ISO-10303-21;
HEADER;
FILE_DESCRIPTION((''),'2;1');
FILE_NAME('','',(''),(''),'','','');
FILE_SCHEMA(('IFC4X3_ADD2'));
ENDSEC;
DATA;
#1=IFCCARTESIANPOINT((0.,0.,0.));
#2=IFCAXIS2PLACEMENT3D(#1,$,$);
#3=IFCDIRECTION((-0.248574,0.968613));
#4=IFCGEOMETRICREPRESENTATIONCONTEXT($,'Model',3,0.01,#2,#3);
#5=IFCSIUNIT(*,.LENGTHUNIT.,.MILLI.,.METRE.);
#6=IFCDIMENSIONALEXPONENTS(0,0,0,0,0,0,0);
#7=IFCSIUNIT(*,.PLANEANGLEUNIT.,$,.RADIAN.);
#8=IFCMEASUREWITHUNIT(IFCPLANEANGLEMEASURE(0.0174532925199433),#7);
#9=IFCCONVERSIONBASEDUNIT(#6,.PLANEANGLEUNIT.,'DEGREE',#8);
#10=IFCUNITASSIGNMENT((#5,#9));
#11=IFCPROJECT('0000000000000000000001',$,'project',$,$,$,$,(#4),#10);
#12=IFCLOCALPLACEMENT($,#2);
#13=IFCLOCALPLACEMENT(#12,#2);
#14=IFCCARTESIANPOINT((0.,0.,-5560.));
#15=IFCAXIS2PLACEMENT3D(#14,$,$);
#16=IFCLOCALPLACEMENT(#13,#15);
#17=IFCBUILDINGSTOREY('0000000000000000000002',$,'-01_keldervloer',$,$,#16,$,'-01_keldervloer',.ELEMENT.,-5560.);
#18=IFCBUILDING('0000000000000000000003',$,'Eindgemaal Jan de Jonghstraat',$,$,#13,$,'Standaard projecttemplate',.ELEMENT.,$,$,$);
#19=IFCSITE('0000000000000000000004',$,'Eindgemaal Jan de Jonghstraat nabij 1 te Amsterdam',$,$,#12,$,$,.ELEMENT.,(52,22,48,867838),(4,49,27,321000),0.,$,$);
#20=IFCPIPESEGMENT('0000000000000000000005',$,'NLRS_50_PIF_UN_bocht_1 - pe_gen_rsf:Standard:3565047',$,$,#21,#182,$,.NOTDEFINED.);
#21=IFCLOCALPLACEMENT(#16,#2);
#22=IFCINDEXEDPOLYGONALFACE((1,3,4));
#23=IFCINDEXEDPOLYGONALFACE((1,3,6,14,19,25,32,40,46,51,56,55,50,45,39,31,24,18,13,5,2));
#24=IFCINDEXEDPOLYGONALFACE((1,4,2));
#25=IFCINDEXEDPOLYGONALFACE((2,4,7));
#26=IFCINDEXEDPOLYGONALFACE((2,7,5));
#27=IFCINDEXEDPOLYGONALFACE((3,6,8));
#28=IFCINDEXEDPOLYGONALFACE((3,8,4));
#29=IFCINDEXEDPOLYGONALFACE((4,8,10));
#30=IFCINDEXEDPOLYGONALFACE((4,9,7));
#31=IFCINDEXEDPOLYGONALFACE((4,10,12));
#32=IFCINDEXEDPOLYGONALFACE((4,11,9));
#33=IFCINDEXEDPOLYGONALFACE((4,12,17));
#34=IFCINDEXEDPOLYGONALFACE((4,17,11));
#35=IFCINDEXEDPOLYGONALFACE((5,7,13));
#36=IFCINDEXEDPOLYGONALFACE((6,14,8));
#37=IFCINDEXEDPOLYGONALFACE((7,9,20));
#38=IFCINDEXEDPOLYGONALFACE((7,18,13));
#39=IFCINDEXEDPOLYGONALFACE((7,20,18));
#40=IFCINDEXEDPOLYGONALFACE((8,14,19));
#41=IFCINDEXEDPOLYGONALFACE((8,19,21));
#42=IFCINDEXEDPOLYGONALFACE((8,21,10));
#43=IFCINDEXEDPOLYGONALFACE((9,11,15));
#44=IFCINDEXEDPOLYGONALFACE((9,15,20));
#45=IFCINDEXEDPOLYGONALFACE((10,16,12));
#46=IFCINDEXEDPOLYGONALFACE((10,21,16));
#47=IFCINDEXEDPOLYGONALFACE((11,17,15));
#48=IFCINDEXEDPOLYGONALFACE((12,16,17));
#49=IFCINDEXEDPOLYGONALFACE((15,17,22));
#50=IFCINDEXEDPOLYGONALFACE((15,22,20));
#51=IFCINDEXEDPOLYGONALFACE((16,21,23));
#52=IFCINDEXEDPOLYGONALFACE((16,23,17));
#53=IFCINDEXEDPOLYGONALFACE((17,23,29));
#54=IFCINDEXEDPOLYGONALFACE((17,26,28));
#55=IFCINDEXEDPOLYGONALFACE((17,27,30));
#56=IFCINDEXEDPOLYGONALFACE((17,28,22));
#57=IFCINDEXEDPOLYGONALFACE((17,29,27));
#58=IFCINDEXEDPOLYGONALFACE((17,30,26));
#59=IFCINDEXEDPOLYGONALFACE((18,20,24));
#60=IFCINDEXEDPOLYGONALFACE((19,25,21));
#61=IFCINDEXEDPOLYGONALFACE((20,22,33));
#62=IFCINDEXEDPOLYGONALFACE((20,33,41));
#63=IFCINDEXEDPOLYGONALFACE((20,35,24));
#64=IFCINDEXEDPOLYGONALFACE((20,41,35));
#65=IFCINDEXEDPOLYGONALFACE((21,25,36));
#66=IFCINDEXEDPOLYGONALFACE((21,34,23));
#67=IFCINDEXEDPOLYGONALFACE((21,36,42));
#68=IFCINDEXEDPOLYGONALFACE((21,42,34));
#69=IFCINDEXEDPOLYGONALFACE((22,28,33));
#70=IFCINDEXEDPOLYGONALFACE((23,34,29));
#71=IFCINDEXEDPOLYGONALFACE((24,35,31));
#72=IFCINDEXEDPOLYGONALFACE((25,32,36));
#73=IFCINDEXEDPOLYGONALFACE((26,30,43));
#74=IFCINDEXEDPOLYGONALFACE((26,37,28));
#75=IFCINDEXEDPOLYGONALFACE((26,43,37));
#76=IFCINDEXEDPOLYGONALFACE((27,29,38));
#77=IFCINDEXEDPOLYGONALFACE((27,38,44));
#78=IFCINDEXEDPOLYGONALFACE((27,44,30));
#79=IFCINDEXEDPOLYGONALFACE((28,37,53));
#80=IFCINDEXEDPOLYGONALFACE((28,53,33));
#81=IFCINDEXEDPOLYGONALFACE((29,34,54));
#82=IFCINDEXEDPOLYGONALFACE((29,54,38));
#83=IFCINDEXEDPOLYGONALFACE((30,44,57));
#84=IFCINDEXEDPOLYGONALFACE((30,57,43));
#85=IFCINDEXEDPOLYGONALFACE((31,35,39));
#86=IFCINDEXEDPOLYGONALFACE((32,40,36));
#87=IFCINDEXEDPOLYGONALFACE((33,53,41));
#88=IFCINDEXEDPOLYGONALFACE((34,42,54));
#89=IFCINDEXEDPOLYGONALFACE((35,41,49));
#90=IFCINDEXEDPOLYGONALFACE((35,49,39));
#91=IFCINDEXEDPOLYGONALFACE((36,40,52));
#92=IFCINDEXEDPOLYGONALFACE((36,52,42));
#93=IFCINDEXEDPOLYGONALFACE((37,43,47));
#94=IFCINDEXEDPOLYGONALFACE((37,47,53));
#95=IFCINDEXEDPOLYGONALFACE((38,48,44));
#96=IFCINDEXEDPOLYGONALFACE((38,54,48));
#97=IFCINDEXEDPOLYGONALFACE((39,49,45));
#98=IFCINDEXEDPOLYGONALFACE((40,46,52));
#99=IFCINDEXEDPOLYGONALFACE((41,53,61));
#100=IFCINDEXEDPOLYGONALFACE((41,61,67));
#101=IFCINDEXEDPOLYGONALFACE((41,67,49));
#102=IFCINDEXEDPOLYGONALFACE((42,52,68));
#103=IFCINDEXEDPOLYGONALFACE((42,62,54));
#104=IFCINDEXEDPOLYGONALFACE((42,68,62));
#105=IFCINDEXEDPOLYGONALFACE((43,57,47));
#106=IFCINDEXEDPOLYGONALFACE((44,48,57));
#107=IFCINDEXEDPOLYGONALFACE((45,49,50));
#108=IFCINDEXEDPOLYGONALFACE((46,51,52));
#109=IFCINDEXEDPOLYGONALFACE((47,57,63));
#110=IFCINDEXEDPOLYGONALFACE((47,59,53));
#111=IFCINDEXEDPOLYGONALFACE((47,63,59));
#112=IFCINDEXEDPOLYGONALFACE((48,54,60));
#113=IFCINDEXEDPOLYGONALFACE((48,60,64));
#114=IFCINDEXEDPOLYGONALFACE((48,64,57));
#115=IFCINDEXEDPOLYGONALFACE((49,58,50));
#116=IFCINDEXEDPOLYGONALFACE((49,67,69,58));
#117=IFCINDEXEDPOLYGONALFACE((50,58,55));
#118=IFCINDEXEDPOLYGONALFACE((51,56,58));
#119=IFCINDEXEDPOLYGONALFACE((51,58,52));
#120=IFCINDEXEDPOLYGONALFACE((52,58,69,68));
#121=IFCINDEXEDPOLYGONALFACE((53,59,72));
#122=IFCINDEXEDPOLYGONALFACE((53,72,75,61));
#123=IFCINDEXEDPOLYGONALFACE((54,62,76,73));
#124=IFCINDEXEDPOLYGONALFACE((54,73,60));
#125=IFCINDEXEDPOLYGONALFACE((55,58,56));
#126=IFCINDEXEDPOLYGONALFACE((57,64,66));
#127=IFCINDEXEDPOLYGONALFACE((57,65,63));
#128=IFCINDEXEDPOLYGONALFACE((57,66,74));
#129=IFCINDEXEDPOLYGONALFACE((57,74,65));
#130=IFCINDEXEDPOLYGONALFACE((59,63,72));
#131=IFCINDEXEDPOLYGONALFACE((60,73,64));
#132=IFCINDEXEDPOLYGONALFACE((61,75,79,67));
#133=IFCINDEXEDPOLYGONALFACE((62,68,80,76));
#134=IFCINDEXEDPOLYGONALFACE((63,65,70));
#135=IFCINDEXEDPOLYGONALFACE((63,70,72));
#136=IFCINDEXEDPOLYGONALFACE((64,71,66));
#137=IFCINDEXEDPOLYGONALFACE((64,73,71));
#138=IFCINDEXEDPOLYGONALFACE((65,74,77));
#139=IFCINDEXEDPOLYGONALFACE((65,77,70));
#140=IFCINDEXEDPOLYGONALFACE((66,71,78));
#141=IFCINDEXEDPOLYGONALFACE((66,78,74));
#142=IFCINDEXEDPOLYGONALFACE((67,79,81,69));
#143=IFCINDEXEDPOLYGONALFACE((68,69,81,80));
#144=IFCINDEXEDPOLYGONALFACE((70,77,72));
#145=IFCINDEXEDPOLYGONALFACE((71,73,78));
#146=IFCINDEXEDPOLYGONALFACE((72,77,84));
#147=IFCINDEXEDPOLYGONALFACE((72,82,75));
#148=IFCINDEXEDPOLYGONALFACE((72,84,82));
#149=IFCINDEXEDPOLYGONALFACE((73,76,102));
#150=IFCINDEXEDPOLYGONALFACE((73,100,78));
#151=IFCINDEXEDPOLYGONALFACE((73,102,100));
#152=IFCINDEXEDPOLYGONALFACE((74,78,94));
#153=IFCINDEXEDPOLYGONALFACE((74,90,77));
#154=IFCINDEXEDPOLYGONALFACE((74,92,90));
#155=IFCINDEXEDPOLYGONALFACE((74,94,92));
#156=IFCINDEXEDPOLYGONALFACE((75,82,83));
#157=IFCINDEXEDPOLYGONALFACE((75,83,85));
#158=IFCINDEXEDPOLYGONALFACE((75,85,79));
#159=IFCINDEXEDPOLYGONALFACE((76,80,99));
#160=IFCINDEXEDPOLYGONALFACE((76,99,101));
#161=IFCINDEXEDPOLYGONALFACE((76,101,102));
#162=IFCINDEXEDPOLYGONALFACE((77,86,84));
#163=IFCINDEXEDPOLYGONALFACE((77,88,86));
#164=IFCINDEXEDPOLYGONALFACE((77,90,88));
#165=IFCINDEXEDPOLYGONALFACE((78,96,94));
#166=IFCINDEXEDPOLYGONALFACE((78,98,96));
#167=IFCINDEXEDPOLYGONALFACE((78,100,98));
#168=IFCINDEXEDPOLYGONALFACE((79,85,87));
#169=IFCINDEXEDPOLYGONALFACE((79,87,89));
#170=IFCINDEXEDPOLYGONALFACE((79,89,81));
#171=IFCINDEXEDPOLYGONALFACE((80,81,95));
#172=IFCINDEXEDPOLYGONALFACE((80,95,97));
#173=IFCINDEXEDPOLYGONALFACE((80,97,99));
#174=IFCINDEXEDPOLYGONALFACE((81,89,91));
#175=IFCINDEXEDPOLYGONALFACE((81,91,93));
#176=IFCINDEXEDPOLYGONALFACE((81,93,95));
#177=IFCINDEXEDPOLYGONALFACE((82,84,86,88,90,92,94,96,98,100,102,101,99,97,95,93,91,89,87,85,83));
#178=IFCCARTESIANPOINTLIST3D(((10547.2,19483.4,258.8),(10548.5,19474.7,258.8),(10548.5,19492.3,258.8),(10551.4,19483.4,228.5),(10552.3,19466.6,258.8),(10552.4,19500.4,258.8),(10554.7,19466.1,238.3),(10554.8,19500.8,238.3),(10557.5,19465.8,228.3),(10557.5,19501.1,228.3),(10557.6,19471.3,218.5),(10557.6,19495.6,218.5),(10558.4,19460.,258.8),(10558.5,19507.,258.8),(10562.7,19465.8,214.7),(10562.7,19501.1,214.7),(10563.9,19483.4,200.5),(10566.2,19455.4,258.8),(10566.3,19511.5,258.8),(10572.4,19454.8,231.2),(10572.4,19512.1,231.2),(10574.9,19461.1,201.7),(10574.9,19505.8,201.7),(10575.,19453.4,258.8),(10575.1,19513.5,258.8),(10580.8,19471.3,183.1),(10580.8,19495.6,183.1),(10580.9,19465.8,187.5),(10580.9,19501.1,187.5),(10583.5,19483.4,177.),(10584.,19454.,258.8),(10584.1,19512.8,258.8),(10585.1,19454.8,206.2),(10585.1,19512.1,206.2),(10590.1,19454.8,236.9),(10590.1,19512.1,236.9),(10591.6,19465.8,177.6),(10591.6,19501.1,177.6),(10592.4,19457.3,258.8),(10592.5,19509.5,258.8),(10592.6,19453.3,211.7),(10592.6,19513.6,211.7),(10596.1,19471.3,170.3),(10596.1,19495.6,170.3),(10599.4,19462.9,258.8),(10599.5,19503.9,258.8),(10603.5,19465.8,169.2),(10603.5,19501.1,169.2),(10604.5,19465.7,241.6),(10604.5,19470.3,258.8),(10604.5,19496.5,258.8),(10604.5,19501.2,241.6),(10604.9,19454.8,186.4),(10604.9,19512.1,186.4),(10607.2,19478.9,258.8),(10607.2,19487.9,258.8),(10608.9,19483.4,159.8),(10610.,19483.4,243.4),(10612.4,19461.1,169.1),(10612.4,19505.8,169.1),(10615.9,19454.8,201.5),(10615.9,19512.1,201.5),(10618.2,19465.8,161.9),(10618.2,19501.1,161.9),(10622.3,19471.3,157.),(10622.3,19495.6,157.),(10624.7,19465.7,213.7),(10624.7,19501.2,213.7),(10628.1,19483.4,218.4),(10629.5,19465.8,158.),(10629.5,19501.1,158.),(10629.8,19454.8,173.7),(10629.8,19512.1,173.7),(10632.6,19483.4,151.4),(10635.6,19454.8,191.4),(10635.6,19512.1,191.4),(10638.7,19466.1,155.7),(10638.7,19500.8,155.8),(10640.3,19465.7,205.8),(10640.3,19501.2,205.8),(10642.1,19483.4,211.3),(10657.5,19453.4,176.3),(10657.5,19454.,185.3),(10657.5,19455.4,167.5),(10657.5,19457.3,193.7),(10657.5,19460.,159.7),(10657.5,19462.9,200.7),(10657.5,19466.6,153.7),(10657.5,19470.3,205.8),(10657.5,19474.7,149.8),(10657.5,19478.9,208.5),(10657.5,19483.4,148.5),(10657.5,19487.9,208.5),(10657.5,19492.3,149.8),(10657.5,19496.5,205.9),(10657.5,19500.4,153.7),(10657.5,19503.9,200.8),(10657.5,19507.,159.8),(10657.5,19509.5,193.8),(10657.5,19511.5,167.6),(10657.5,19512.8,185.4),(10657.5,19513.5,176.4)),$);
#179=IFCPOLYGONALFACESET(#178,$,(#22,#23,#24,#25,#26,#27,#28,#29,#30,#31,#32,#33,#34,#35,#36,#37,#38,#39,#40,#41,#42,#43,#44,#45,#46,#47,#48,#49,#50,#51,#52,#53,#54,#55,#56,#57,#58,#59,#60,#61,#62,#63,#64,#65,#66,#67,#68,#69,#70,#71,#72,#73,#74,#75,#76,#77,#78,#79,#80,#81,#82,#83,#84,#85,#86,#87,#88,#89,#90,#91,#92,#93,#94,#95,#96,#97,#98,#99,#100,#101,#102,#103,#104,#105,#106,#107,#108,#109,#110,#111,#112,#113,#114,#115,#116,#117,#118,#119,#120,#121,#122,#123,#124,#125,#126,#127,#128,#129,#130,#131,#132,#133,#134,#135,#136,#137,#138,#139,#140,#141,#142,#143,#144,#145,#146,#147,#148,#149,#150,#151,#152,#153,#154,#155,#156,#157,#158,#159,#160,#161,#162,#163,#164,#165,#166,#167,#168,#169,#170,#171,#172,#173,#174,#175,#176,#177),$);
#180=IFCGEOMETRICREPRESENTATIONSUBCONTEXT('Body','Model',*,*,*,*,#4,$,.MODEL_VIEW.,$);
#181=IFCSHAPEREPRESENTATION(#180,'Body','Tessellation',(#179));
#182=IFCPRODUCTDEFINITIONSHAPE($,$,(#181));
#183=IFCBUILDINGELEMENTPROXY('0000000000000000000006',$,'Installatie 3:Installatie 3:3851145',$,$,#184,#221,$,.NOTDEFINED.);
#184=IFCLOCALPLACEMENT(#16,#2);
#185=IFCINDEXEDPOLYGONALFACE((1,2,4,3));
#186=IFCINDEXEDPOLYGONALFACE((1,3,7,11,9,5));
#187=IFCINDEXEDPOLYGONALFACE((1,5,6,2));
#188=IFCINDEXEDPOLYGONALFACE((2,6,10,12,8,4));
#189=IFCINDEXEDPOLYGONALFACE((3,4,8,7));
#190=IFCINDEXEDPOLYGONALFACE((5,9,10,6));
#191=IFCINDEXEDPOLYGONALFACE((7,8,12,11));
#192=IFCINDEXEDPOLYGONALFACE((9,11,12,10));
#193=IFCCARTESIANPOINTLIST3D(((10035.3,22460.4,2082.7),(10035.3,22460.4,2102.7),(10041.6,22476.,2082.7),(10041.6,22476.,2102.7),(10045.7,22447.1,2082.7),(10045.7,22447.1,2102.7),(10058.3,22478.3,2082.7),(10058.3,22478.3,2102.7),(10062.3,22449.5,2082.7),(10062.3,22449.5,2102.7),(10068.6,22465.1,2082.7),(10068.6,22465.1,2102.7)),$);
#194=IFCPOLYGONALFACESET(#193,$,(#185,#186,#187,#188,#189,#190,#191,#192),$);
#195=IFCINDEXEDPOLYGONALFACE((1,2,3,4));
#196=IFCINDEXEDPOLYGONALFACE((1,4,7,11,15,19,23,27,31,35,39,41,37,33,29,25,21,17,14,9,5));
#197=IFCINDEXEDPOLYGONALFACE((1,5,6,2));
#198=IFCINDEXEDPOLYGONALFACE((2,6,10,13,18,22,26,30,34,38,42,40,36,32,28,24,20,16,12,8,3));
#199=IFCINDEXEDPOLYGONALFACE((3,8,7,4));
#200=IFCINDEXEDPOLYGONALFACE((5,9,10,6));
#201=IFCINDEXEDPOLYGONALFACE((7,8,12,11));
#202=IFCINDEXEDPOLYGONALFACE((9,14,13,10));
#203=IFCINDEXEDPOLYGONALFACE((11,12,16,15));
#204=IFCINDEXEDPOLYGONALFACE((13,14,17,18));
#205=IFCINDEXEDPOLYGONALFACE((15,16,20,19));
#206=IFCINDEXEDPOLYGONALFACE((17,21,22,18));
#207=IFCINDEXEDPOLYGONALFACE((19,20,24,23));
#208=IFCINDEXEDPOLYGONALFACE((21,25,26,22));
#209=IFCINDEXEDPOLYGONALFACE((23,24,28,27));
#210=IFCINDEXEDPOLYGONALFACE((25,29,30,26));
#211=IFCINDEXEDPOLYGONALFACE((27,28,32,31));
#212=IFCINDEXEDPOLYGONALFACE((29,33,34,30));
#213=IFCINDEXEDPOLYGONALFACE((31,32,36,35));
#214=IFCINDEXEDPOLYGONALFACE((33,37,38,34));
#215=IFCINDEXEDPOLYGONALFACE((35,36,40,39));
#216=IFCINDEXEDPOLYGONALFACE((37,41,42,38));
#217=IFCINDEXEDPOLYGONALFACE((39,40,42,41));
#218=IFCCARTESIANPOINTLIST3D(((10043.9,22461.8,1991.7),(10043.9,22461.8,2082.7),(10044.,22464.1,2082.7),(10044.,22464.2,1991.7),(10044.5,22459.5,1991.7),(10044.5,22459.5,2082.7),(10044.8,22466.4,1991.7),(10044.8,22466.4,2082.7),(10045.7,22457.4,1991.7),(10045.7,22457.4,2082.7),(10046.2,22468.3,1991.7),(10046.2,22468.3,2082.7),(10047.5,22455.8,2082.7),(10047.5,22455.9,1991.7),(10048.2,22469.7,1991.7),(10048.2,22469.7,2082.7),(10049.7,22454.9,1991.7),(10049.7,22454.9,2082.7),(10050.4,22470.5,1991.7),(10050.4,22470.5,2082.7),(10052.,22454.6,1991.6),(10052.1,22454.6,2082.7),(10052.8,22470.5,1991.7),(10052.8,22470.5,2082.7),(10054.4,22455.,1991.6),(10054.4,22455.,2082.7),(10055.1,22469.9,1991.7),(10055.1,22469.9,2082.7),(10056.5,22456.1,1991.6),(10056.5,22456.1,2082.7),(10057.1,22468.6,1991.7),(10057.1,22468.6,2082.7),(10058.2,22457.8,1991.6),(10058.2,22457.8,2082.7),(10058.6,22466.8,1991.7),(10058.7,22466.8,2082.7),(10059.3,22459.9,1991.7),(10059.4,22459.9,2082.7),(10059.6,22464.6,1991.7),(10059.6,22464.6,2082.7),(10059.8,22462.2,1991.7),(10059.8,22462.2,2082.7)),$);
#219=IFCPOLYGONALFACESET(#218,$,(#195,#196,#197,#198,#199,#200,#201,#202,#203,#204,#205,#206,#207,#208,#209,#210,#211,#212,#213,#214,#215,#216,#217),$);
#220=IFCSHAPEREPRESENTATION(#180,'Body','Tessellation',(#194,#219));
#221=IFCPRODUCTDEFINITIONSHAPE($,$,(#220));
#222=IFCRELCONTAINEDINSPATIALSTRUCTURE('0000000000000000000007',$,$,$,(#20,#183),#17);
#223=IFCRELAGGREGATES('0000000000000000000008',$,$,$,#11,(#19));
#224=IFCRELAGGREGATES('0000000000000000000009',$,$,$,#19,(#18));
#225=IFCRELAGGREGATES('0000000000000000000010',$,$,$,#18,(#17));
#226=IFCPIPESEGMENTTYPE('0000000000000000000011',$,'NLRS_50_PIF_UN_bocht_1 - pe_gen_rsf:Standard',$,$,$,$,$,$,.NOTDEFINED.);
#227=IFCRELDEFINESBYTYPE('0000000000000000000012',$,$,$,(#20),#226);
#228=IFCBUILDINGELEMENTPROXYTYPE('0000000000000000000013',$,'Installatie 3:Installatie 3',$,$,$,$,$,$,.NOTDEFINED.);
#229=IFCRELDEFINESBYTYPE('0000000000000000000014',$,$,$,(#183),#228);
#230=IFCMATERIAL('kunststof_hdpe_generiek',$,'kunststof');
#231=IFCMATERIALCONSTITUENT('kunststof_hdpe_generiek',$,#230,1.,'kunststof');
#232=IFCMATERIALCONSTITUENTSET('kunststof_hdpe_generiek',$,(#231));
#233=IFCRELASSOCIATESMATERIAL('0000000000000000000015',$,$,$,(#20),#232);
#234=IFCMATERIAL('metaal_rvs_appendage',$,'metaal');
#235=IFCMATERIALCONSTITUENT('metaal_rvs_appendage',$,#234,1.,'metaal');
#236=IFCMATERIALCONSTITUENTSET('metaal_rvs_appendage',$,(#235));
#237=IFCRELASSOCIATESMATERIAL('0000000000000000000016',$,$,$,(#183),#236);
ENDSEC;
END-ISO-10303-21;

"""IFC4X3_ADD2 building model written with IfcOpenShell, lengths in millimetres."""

from ifc_helpers import new_model, entity, si_unit, converted_unit, direction, frame, frame_2d, origin, place, context, subcontext, project, spatial, polyline, circle, outline, extrude, source, transform, mapped, material, constituent, constituent_set, type_object, type_shapes, element, save


model = new_model("IFC4X3_ADD2")

# Units and contexts
model_context = context("Model", 3, precision=0.01, world=origin(), true_north=direction((-0.248574, 0.968613)))
body_context = subcontext(model_context, "Body", "Model", "MODEL_VIEW")
ifc_project = project(units=[si_unit("LENGTHUNIT", "METRE", prefix="MILLI"), converted_unit("PLANEANGLEUNIT", "DEGREE", entity("IfcPlaneAngleMeasure", 0.0174532925199433), si_unit("PLANEANGLEUNIT", "RADIAN"), dimensions=[0, 0, 0, 0, 0, 0, 0])], contexts=[model_context])

# Site, building, storey
site_placement = place(None, origin())
site = spatial("IfcSite", under=ifc_project, at=site_placement, Name="Eindgemaal Jan de Jonghstraat nabij 1 te Amsterdam", CompositionType="ELEMENT", RefLatitude=(52, 22, 48, 867838), RefLongitude=(4, 49, 27, 321000), RefElevation=0.0)
building_placement = place(site_placement, origin())
building = spatial("IfcBuilding", under=site, at=building_placement, Name="Eindgemaal Jan de Jonghstraat", LongName="Standaard projecttemplate", CompositionType="ELEMENT")
storey_placement = place(building_placement, frame((0.0, 0.0, -5560.0)))
storey = spatial("IfcBuildingStorey", under=building, at=storey_placement, Name="-01_keldervloer", LongName="-01_keldervloer", CompositionType="ELEMENT", Elevation=-5560.0)

# Pipe segment
ifc_material_1 = material(Name="kunststof_hdpe_generiek", Category="kunststof")
ifc_constituent_1 = constituent(ifc_material_1, Name="kunststof_hdpe_generiek", Category="kunststof", fraction=1.0)
ifc_constituent_set_1 = constituent_set(constituents=[ifc_constituent_1], Name="kunststof_hdpe_generiek")
pipe_segment_type_1 = type_object("IfcPipeSegmentType", Name="NLRS_50_PIF_UN_bocht_1 - pe_gen_rsf:Standard", PredefinedType="NOTDEFINED")
trimmed_curve_1 = entity("IfcTrimmedCurve", entity("IfcCircle", entity("IfcAxis2Placement2D", entity("IfcCartesianPoint", [-50.0, 0.0]), entity("IfcDirection", [0.0, 1.0])), 50.0), [entity("IfcParameterValue", 270.0)], [entity("IfcParameterValue", 0.0)], True, "PARAMETER")
shared_shape_1 = source(origin(), body_context, "Body", "AdvancedSweptSolid", [
    entity("IfcSurfaceCurveSweptAreaSolid", entity("IfcCircleProfileDef", "AREA", None, entity("IfcAxis2Placement2D", entity("IfcCartesianPoint", [30.1, 0.0]), entity("IfcDirection", [1.0, 0.0])), 30.1), entity("IfcAxis2Placement3D", entity("IfcCartesianPoint", [-30.1, 80.1, 0.0]), entity("IfcDirection", [0.0, 0.0, -1.0]), entity("IfcDirection", [1.0, 0.0, 0.0])), trimmed_curve_1, entity("IfcParameterValue", 0.0), entity("IfcParameterValue", 90.0), entity("IfcSurfaceOfLinearExtrusion", entity("IfcArbitraryOpenProfileDef", "CURVE", None, trimmed_curve_1), entity("IfcAxis2Placement3D", entity("IfcCartesianPoint", [0.0, 0.0, -304.8])), entity("IfcDirection", [0.0, 0.0, 1.0]), 1.0)),
])
type_shapes(pipe_segment_type_1, [shared_shape_1])
pipe_segment_1_placement = place(storey_placement, frame((10577.4, 19483.4, 178.7), z_axis=(0.0, 1.0, 0.0), x_axis=(-1.0, 0.0, 0.0)))
element("IfcPipeSegment", 1, at=pipe_segment_1_placement, inside=storey, type_object=pipe_segment_type_1, material=ifc_constituent_set_1, Name="NLRS_50_PIF_UN_bocht_1 - pe_gen_rsf:Standard:3565047", PredefinedType="NOTDEFINED", context=body_context, shape_type="MappedRepresentation", body=[
    mapped(shared_shape_1, transform((0.0, 0.0, 0.0), scale=1.0)),
])

# Building element proxy
ifc_material_2 = material(Name="metaal_rvs_appendage", Category="metaal")
ifc_constituent_2 = constituent(ifc_material_2, Name="metaal_rvs_appendage", Category="metaal", fraction=1.0)
ifc_constituent_set_2 = constituent_set(constituents=[ifc_constituent_2], Name="metaal_rvs_appendage")
building_element_proxy_type_1 = type_object("IfcBuildingElementProxyType", Name="Installatie 3:Installatie 3", PredefinedType="NOTDEFINED")
shared_shape_2 = source(origin(), body_context, "Body", "SweptSolid", [
    extrude(outline(polyline([(-8.4, -14.6), (8.4, -14.6), (16.8, 0.0), (8.4, 14.6), (-8.4, 14.6), (-16.8, 0.0), (-8.4, -14.6)])), frame((0.0, 0.0, 41.5), z_axis=(0.0, 0.0, 1.0), x_axis=(-0.400458, 0.916315, 0.0)), (0.0, 0.0, 1.0), 20.0),
    extrude(circle(Radius=8.0, at=frame_2d((0.0, 0.0), x_axis=(1.0, 0.0))), frame((-0.2, -0.1, -49.5), z_axis=(0.000101, -0.000286, 1.0), x_axis=(1.0, 0.0, -0.000101)), (0.0, 0.0, 1.0), 91.1),
])
type_shapes(building_element_proxy_type_1, [shared_shape_2])
for number, where, z_axis, x_axis, name in (
    (2, (10052.0, 22462.7, 2041.2), (0.0, 0.0, 1.0), (0.968613, 0.248574, 0.0), "Installatie 3:Installatie 3:3851145"),
):
    element("IfcBuildingElementProxy", number, at=place(storey_placement, frame(where, z_axis=z_axis, x_axis=x_axis)), inside=storey, type_object=building_element_proxy_type_1, material=ifc_constituent_set_2, Name=name, PredefinedType="NOTDEFINED", context=body_context, shape_type="MappedRepresentation", body=[
        mapped(shared_shape_2, transform((0.0, 0.0, 0.0), scale=1.0)),
    ])

save(model, "model.ifc")
